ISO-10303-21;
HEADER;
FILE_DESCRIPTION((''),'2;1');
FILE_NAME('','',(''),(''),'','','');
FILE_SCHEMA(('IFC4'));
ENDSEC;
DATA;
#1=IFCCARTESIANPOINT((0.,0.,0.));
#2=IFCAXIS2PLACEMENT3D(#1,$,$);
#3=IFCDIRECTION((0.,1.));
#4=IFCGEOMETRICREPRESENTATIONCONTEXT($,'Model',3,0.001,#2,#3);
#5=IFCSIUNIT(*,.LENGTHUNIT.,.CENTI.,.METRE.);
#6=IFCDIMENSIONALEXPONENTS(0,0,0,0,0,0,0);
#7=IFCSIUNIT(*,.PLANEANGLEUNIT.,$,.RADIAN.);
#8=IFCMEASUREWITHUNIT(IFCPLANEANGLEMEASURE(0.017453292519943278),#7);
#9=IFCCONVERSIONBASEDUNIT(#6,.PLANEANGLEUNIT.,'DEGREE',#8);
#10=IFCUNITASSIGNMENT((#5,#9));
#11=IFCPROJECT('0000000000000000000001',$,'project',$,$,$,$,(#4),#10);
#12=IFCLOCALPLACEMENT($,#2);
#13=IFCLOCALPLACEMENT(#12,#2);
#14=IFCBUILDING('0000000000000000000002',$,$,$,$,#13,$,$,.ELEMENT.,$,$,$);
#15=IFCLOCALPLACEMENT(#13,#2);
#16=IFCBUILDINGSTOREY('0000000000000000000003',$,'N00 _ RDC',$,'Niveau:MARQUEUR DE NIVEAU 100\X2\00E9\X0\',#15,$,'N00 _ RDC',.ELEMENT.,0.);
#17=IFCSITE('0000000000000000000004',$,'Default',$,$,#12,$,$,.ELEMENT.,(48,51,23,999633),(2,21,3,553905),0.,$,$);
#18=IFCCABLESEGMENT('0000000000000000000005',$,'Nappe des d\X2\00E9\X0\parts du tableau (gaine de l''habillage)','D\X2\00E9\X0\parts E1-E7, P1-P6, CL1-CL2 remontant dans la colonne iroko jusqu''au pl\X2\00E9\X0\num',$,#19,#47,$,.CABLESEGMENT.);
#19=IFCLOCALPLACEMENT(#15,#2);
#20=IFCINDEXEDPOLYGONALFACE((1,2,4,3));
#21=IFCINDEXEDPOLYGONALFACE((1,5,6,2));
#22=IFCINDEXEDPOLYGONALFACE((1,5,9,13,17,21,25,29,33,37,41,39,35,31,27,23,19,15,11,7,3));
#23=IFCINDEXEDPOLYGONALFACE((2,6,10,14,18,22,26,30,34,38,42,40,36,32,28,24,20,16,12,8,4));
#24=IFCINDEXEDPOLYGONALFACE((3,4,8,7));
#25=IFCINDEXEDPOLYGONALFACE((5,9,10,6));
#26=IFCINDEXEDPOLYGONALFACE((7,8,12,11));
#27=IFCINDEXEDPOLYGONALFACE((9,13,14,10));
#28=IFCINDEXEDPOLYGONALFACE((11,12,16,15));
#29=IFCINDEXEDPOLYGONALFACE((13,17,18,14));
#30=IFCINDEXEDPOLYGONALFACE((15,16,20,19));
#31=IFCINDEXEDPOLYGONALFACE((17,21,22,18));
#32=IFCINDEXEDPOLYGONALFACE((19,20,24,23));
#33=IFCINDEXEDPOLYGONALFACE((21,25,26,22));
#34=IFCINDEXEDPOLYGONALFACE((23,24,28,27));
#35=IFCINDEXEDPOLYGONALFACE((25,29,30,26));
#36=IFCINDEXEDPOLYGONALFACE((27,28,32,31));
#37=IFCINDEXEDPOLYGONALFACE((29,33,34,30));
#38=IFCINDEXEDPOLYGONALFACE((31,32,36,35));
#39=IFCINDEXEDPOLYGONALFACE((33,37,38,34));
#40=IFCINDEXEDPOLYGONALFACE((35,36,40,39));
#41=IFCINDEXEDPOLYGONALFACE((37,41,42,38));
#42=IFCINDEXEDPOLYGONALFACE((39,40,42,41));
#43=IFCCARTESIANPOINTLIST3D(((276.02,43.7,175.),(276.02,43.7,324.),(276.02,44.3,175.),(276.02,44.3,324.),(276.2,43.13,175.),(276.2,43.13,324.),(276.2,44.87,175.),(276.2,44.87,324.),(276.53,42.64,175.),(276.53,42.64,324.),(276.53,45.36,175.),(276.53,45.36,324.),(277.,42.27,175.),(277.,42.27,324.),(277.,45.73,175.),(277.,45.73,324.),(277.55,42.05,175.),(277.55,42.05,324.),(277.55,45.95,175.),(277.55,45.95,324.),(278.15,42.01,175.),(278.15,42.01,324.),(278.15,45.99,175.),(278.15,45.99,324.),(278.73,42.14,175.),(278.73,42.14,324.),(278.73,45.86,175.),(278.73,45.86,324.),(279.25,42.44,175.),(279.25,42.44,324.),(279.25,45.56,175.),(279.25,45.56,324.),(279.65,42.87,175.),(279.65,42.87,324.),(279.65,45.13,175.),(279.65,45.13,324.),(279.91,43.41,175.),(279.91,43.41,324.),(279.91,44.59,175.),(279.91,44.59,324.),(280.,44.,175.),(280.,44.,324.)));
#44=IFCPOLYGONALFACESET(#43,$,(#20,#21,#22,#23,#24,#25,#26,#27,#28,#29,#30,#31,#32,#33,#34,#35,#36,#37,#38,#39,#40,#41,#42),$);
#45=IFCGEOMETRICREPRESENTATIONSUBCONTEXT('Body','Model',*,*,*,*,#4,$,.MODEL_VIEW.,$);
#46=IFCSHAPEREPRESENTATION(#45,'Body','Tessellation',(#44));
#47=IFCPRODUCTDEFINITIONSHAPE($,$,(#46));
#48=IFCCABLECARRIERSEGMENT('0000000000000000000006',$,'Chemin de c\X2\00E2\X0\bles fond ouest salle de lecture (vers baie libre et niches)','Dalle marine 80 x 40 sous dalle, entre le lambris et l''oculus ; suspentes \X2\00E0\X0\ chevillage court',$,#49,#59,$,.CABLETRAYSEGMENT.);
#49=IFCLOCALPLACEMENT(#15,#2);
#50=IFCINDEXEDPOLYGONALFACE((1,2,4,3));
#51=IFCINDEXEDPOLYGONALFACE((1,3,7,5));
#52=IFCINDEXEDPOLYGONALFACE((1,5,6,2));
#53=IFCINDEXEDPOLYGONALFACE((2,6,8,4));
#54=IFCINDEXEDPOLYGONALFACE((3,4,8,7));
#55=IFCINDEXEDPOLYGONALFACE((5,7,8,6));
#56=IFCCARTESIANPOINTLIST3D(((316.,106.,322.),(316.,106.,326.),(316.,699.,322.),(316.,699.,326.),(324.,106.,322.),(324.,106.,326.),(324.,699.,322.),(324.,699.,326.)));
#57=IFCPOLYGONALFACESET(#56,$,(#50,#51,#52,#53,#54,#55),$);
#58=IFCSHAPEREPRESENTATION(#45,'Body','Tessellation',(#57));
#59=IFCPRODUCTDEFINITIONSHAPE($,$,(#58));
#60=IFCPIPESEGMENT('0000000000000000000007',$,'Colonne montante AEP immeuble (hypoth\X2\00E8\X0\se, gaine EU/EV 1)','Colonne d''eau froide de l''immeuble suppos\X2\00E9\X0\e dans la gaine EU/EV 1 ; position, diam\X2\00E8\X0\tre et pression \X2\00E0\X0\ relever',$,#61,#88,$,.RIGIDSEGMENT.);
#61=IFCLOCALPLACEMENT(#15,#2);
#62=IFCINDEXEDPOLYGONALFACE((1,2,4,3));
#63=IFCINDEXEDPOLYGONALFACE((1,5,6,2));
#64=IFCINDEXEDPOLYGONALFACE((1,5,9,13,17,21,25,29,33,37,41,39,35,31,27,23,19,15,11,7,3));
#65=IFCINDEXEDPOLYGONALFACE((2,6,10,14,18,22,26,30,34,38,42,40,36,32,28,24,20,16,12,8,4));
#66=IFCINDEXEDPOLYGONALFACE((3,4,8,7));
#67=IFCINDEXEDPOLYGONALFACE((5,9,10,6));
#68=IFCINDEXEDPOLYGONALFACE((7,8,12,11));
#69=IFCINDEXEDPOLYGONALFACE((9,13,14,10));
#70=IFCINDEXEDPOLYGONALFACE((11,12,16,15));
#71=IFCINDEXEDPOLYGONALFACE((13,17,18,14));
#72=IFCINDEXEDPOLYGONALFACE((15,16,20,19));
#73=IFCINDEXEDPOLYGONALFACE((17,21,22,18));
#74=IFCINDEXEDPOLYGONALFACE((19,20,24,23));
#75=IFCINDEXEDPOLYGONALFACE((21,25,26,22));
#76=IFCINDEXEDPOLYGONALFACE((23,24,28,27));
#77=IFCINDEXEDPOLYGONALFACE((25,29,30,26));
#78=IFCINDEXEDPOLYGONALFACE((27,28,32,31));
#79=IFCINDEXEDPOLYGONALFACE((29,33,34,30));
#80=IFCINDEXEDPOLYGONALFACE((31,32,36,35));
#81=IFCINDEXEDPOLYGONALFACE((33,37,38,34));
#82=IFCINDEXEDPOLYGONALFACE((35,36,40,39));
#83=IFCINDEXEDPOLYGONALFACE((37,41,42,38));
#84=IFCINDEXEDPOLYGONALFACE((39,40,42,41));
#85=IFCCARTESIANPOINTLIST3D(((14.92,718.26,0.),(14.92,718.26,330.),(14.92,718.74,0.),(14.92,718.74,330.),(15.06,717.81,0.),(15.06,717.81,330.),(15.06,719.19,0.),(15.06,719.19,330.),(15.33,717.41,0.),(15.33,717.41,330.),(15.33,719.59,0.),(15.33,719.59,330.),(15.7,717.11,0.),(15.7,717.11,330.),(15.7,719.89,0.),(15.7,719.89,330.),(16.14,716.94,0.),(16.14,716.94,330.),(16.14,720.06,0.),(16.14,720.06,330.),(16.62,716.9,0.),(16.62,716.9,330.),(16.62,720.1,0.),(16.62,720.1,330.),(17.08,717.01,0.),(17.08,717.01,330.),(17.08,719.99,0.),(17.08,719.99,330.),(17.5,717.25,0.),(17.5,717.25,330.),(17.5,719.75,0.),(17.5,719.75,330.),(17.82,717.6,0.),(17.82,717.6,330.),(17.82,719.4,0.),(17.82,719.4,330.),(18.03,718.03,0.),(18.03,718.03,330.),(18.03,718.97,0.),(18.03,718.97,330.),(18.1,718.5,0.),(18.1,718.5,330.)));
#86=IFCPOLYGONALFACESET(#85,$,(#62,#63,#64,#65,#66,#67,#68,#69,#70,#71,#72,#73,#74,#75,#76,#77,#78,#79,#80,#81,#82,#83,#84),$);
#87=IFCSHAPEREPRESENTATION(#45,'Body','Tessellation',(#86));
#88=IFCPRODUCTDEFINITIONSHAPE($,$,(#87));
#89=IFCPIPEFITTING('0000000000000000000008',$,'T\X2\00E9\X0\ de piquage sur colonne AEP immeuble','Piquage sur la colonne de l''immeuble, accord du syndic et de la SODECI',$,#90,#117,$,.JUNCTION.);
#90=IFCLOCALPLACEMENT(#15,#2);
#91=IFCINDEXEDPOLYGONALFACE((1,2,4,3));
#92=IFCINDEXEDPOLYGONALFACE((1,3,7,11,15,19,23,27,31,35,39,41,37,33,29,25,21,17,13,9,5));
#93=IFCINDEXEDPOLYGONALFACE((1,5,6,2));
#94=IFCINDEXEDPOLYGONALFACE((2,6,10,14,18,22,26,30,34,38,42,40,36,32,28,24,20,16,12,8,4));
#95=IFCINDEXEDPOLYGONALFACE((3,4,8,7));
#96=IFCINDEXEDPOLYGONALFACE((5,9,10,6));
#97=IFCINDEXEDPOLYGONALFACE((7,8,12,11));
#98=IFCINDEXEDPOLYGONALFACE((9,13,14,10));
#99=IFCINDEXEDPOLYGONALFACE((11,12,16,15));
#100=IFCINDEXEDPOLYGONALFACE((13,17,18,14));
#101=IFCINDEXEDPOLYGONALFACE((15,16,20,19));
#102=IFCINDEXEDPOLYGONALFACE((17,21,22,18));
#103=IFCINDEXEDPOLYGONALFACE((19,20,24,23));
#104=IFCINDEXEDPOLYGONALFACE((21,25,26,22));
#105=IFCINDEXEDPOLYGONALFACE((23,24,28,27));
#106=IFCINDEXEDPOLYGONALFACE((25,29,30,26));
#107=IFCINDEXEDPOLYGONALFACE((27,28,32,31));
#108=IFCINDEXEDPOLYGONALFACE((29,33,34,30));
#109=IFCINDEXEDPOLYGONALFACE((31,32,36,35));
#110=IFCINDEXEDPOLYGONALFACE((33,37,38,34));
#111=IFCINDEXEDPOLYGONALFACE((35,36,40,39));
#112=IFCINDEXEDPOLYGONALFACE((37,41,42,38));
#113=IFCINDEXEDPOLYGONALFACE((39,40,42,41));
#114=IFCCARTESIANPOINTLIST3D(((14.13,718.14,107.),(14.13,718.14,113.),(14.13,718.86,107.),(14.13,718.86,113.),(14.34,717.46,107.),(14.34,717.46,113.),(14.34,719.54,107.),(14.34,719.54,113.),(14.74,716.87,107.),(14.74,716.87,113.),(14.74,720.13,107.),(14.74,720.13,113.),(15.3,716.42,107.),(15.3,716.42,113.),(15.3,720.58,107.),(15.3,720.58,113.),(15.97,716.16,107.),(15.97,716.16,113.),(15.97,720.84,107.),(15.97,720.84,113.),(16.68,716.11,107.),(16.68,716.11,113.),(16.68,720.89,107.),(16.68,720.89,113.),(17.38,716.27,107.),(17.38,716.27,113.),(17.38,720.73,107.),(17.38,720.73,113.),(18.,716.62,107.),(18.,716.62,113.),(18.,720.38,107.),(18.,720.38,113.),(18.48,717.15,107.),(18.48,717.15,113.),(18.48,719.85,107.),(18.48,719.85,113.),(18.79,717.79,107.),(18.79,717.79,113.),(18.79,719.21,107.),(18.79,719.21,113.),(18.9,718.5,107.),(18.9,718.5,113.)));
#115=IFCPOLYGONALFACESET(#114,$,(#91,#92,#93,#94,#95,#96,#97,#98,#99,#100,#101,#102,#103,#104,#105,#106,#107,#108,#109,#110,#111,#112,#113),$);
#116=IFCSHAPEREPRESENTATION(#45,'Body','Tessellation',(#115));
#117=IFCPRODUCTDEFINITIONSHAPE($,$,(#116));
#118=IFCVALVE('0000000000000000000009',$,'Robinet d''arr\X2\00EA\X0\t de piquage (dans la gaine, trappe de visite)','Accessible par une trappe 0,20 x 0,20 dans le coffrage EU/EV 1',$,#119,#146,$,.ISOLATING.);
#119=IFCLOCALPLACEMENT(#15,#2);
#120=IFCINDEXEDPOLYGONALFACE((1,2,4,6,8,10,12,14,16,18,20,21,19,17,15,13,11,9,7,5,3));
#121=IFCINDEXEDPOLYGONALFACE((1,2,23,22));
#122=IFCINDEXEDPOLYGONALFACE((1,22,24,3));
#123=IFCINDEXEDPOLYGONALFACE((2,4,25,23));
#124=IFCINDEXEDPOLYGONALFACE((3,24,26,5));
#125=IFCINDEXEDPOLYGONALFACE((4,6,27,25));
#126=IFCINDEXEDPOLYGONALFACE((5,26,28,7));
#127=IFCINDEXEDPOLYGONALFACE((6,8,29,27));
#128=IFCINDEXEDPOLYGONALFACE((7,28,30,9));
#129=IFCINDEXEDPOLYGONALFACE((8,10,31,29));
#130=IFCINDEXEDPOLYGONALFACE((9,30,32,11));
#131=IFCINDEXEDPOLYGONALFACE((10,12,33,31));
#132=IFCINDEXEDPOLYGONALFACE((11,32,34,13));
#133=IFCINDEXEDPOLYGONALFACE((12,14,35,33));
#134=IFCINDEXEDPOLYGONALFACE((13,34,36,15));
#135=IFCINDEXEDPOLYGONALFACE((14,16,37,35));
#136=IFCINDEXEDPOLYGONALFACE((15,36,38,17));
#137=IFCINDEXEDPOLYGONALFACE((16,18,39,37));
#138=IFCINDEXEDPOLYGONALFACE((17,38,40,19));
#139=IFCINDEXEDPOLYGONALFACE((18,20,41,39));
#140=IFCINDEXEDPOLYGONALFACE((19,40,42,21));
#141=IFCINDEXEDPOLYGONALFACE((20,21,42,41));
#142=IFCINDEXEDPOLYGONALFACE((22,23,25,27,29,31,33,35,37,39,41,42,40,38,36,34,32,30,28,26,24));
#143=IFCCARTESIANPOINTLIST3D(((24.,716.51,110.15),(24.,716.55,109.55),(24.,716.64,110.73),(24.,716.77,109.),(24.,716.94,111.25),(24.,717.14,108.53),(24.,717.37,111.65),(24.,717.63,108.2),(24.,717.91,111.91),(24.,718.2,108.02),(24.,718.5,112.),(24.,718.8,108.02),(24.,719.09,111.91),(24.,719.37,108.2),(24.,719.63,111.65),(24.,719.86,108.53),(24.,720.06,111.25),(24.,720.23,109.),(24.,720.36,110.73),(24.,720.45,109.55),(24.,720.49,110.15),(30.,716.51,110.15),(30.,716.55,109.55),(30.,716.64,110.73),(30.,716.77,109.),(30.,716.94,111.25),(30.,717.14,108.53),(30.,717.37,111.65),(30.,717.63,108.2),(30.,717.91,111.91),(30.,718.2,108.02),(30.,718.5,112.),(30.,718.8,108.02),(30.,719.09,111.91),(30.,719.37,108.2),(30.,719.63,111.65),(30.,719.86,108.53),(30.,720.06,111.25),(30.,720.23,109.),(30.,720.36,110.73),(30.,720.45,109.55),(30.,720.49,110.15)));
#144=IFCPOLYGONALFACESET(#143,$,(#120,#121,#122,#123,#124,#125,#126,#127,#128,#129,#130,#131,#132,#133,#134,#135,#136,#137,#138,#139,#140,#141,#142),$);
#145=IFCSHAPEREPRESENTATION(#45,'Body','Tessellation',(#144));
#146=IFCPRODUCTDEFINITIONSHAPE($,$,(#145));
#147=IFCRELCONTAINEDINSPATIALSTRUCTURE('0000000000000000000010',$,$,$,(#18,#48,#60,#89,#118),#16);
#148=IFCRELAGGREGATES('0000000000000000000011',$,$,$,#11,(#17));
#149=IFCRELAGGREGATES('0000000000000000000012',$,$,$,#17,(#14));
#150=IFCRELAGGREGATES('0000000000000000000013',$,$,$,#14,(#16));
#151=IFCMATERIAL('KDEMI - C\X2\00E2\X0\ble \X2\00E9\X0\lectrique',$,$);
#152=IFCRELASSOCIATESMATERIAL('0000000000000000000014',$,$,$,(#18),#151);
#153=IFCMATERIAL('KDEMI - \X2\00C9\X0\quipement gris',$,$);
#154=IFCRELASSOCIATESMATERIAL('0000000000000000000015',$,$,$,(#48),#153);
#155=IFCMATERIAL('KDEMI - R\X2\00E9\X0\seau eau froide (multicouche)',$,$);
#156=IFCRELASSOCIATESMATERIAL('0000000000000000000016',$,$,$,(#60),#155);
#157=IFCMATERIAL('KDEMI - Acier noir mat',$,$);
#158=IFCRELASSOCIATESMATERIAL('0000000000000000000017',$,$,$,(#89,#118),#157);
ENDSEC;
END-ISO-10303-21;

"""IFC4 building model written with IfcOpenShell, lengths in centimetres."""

from ifc_helpers import new_model, entity, si_unit, converted_unit, direction, frame, frame_2d, origin, origin_with_axes, place, context, subcontext, project, spatial, rectangle, circle, extrude, material, element, save


model = new_model("IFC4")

# Units and contexts
model_context = context("Model", 3, precision=0.001, world=origin(), true_north=direction((0.0, 1.0)))
body_context = subcontext(model_context, "Body", "Model", "MODEL_VIEW")
ifc_project = project(units=[si_unit("LENGTHUNIT", "METRE", prefix="CENTI"), converted_unit("PLANEANGLEUNIT", "DEGREE", entity("IfcPlaneAngleMeasure", 0.017453292519943278), si_unit("PLANEANGLEUNIT", "RADIAN"), dimensions=[0, 0, 0, 0, 0, 0, 0])], contexts=[model_context])

# Site, building, storey
site_placement = place(None, origin())
site = spatial("IfcSite", under=ifc_project, at=site_placement, Name="Default", CompositionType="ELEMENT", RefLatitude=(48, 51, 23, 999633), RefLongitude=(2, 21, 3, 553905), RefElevation=0.0)
building_placement = place(site_placement, origin())
building = spatial("IfcBuilding", under=site, at=building_placement, CompositionType="ELEMENT")
storey_placement = place(building_placement, origin())
storey = spatial("IfcBuildingStorey", under=building, at=storey_placement, Name="N00 _ RDC", ObjectType="Niveau:MARQUEUR DE NIVEAU 100é", LongName="N00 _ RDC", CompositionType="ELEMENT", Elevation=0.0)

# Cable segment
ifc_material_1 = material(Name="KDEMI - Câble électrique")
cable_segment_1_placement = place(storey_placement, origin_with_axes())
element("IfcCableSegment", 1, at=cable_segment_1_placement, inside=storey, material=ifc_material_1, Name="Nappe des départs du tableau (gaine de l'habillage)", Description="Départs E1-E7, P1-P6, CL1-CL2 remontant dans la colonne iroko jusqu'au plénum", PredefinedType="CABLESEGMENT", context=body_context, shape_type="AdvancedSweptSolid", body=[
    entity("IfcSweptDiskSolid", entity("IfcPolyline", [entity("IfcCartesianPoint", [278.0, 44.0, 175.0]), entity("IfcCartesianPoint", [278.0, 44.0, 324.0])]), 2.0),
])

# Cable carrier segment
ifc_material_2 = material(Name="KDEMI - Équipement gris")
cable_carrier_segment_placement = place(storey_placement, origin_with_axes())
element("IfcCableCarrierSegment", 2, at=cable_carrier_segment_placement, inside=storey, material=ifc_material_2, Name="Chemin de câbles fond ouest salle de lecture (vers baie libre et niches)", Description="Dalle marine 80 x 40 sous dalle, entre le lambris et l'oculus ; suspentes à chevillage court", PredefinedType="CABLETRAYSEGMENT", context=body_context, shape_type="SweptSolid", body=[
    extrude(rectangle(XDim=8.0, YDim=593.0, at=frame_2d((320.0, 402.5))), frame((0.0, 0.0, 322.0)), (0.0, 0.0, 1.0), 4.0),
])

# Pipe segment
ifc_material_3 = material(Name="KDEMI - Réseau eau froide (multicouche)")
pipe_segment_1_placement = place(storey_placement, origin_with_axes())
element("IfcPipeSegment", 3, at=pipe_segment_1_placement, inside=storey, material=ifc_material_3, Name="Colonne montante AEP immeuble (hypothèse, gaine EU/EV 1)", Description="Colonne d'eau froide de l'immeuble supposée dans la gaine EU/EV 1 ; position, diamètre et pression à relever", PredefinedType="RIGIDSEGMENT", context=body_context, shape_type="AdvancedSweptSolid", body=[
    entity("IfcSweptDiskSolid", entity("IfcPolyline", [entity("IfcCartesianPoint", [16.5, 718.5, 0.0]), entity("IfcCartesianPoint", [16.5, 718.5, 330.0])]), 1.6),
])

# Pipe fitting
ifc_material_4 = material(Name="KDEMI - Acier noir mat")
pipe_fitting_placement = place(storey_placement, origin_with_axes())
element("IfcPipeFitting", 4, at=pipe_fitting_placement, inside=storey, material=ifc_material_4, Name="Té de piquage sur colonne AEP immeuble", Description="Piquage sur la colonne de l'immeuble, accord du syndic et de la SODECI", PredefinedType="JUNCTION", context=body_context, shape_type="SweptSolid", body=[
    extrude(circle(Radius=2.4, at=frame_2d((16.5, 718.5))), frame((0.0, 0.0, 107.0)), (0.0, 0.0, 1.0), 6.0),
])

# Valve
valve_1_placement = place(storey_placement, origin_with_axes())
element("IfcValve", 5, at=valve_1_placement, inside=storey, material=ifc_material_4, Name="Robinet d'arrêt de piquage (dans la gaine, trappe de visite)", Description="Accessible par une trappe 0,20 x 0,20 dans le coffrage EU/EV 1", PredefinedType="ISOLATING", context=body_context, shape_type="AdvancedSweptSolid", body=[
    entity("IfcSweptDiskSolid", entity("IfcPolyline", [entity("IfcCartesianPoint", [24.0, 718.5, 110.0]), entity("IfcCartesianPoint", [30.0, 718.5, 110.0])]), 2.0),
])

save(model, "model.ifc")
